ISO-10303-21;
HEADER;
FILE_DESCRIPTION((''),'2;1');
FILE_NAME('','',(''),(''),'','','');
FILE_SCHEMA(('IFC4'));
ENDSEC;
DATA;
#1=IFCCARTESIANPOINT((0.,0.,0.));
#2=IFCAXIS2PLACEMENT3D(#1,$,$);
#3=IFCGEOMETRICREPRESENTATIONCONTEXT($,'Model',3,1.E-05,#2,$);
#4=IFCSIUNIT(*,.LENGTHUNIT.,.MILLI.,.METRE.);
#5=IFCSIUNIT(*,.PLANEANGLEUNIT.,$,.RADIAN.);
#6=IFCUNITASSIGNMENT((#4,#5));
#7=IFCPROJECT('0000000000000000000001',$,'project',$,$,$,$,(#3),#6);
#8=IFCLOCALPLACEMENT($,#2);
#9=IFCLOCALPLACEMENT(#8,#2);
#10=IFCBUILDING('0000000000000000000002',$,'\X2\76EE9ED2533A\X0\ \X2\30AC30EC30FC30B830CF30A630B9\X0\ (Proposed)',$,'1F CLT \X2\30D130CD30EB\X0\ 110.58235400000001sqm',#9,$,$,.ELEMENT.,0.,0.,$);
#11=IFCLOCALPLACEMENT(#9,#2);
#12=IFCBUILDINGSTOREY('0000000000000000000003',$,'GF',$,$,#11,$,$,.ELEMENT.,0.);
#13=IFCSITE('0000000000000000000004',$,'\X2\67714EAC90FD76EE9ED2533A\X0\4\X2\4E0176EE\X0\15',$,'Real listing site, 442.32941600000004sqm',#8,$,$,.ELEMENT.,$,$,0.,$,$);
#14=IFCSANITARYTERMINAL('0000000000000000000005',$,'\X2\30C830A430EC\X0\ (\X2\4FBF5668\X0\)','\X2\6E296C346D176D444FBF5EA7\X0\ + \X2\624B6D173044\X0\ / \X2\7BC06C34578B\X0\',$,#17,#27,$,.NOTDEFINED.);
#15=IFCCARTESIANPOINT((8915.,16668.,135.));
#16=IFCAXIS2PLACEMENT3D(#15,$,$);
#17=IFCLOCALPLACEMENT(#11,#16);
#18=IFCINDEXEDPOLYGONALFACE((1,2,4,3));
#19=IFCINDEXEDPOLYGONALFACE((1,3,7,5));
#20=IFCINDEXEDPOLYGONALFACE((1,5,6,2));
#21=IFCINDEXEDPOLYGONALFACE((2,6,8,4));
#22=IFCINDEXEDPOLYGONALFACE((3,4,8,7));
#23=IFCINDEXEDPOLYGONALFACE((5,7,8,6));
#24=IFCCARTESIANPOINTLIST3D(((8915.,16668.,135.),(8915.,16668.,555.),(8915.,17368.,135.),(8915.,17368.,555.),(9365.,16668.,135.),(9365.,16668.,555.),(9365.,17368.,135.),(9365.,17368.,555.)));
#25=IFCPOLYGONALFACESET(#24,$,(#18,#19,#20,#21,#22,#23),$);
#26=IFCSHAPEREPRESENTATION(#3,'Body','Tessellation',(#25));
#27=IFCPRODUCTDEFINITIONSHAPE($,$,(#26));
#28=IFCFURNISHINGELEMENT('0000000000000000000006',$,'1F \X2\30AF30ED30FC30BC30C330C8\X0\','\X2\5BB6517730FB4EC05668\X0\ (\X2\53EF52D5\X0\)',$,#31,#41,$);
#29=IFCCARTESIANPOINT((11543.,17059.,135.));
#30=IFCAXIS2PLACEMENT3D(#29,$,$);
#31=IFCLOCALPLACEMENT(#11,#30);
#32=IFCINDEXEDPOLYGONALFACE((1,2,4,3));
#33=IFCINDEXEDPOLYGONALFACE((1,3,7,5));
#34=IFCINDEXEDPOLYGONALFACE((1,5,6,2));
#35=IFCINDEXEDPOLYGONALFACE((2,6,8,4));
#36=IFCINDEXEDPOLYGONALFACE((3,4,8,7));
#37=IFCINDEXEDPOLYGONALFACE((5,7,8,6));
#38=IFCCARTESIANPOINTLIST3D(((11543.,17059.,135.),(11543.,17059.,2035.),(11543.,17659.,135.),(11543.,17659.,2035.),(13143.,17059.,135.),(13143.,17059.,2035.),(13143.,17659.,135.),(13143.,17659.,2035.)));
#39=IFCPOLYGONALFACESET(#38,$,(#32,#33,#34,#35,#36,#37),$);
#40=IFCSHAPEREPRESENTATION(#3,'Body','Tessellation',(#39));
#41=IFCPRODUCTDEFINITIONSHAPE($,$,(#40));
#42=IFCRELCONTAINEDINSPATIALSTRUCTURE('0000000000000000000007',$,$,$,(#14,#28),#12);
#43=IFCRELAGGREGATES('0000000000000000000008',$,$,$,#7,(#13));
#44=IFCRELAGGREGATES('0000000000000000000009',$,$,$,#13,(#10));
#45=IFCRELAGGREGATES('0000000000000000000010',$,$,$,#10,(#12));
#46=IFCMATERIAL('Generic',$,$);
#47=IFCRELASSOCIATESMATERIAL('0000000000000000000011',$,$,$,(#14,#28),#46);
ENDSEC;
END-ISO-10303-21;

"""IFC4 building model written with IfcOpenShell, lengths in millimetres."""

from ifc_helpers import new_model, si_unit, frame, frame_2d, origin, place, context, project, spatial, rectangle, extrude, material, element, save


model = new_model("IFC4")

# Units and contexts
model_context = context("Model", 3, precision=1e-05, world=origin())
ifc_project = project(units=[si_unit("LENGTHUNIT", "METRE", prefix="MILLI"), si_unit("PLANEANGLEUNIT", "RADIAN")], contexts=[model_context])

# Site, building, storey
site_placement = place(None, origin())
site = spatial("IfcSite", under=ifc_project, at=site_placement, Name="東京都目黒区4丁目15", ObjectType="Real listing site, 442.32941600000004sqm", CompositionType="ELEMENT", RefElevation=0.0)
building_placement = place(site_placement, origin())
building = spatial("IfcBuilding", under=site, at=building_placement, Name="目黒区 ガレージハウス (Proposed)", ObjectType="1F CLT パネル 110.58235400000001sqm", CompositionType="ELEMENT", ElevationOfRefHeight=0.0, ElevationOfTerrain=0.0)
storey_placement = place(building_placement, origin())
storey = spatial("IfcBuildingStorey", under=building, at=storey_placement, Name="GF", CompositionType="ELEMENT", Elevation=0.0)

# Shared definitions
ifc_material_1 = material(Name="Generic")

# Sanitary terminal
sanitary_terminal_1_placement = place(storey_placement, frame((8915.0, 16668.0, 135.0)))
element("IfcSanitaryTerminal", 1, at=sanitary_terminal_1_placement, inside=storey, material=ifc_material_1, Name="トイレ (便器)", Description="温水洗浄便座 + 手洗い / 節水型", PredefinedType="NOTDEFINED", context=model_context, shape_type="SweptSolid", body=[
    extrude(rectangle(XDim=450.0, YDim=700.0, at=frame_2d((225.0, 350.0))), frame((8915.0, 16668.0, 135.0)), (0.0, 0.0, 1.0), 420.0),
])

# Furnishing element
furnishing_placement = place(storey_placement, frame((11543.0, 17059.0, 135.0)))
element("IfcFurnishingElement", 2, at=furnishing_placement, inside=storey, material=ifc_material_1, Name="1F クローゼット", Description="家具・什器 (可動)", context=model_context, shape_type="SweptSolid", body=[
    extrude(rectangle(XDim=1600.0, YDim=600.0, at=frame_2d((800.0, 300.0))), frame((11543.0, 17059.0, 135.0)), (0.0, 0.0, 1.0), 1900.0),
])

save(model, "model.ifc")
